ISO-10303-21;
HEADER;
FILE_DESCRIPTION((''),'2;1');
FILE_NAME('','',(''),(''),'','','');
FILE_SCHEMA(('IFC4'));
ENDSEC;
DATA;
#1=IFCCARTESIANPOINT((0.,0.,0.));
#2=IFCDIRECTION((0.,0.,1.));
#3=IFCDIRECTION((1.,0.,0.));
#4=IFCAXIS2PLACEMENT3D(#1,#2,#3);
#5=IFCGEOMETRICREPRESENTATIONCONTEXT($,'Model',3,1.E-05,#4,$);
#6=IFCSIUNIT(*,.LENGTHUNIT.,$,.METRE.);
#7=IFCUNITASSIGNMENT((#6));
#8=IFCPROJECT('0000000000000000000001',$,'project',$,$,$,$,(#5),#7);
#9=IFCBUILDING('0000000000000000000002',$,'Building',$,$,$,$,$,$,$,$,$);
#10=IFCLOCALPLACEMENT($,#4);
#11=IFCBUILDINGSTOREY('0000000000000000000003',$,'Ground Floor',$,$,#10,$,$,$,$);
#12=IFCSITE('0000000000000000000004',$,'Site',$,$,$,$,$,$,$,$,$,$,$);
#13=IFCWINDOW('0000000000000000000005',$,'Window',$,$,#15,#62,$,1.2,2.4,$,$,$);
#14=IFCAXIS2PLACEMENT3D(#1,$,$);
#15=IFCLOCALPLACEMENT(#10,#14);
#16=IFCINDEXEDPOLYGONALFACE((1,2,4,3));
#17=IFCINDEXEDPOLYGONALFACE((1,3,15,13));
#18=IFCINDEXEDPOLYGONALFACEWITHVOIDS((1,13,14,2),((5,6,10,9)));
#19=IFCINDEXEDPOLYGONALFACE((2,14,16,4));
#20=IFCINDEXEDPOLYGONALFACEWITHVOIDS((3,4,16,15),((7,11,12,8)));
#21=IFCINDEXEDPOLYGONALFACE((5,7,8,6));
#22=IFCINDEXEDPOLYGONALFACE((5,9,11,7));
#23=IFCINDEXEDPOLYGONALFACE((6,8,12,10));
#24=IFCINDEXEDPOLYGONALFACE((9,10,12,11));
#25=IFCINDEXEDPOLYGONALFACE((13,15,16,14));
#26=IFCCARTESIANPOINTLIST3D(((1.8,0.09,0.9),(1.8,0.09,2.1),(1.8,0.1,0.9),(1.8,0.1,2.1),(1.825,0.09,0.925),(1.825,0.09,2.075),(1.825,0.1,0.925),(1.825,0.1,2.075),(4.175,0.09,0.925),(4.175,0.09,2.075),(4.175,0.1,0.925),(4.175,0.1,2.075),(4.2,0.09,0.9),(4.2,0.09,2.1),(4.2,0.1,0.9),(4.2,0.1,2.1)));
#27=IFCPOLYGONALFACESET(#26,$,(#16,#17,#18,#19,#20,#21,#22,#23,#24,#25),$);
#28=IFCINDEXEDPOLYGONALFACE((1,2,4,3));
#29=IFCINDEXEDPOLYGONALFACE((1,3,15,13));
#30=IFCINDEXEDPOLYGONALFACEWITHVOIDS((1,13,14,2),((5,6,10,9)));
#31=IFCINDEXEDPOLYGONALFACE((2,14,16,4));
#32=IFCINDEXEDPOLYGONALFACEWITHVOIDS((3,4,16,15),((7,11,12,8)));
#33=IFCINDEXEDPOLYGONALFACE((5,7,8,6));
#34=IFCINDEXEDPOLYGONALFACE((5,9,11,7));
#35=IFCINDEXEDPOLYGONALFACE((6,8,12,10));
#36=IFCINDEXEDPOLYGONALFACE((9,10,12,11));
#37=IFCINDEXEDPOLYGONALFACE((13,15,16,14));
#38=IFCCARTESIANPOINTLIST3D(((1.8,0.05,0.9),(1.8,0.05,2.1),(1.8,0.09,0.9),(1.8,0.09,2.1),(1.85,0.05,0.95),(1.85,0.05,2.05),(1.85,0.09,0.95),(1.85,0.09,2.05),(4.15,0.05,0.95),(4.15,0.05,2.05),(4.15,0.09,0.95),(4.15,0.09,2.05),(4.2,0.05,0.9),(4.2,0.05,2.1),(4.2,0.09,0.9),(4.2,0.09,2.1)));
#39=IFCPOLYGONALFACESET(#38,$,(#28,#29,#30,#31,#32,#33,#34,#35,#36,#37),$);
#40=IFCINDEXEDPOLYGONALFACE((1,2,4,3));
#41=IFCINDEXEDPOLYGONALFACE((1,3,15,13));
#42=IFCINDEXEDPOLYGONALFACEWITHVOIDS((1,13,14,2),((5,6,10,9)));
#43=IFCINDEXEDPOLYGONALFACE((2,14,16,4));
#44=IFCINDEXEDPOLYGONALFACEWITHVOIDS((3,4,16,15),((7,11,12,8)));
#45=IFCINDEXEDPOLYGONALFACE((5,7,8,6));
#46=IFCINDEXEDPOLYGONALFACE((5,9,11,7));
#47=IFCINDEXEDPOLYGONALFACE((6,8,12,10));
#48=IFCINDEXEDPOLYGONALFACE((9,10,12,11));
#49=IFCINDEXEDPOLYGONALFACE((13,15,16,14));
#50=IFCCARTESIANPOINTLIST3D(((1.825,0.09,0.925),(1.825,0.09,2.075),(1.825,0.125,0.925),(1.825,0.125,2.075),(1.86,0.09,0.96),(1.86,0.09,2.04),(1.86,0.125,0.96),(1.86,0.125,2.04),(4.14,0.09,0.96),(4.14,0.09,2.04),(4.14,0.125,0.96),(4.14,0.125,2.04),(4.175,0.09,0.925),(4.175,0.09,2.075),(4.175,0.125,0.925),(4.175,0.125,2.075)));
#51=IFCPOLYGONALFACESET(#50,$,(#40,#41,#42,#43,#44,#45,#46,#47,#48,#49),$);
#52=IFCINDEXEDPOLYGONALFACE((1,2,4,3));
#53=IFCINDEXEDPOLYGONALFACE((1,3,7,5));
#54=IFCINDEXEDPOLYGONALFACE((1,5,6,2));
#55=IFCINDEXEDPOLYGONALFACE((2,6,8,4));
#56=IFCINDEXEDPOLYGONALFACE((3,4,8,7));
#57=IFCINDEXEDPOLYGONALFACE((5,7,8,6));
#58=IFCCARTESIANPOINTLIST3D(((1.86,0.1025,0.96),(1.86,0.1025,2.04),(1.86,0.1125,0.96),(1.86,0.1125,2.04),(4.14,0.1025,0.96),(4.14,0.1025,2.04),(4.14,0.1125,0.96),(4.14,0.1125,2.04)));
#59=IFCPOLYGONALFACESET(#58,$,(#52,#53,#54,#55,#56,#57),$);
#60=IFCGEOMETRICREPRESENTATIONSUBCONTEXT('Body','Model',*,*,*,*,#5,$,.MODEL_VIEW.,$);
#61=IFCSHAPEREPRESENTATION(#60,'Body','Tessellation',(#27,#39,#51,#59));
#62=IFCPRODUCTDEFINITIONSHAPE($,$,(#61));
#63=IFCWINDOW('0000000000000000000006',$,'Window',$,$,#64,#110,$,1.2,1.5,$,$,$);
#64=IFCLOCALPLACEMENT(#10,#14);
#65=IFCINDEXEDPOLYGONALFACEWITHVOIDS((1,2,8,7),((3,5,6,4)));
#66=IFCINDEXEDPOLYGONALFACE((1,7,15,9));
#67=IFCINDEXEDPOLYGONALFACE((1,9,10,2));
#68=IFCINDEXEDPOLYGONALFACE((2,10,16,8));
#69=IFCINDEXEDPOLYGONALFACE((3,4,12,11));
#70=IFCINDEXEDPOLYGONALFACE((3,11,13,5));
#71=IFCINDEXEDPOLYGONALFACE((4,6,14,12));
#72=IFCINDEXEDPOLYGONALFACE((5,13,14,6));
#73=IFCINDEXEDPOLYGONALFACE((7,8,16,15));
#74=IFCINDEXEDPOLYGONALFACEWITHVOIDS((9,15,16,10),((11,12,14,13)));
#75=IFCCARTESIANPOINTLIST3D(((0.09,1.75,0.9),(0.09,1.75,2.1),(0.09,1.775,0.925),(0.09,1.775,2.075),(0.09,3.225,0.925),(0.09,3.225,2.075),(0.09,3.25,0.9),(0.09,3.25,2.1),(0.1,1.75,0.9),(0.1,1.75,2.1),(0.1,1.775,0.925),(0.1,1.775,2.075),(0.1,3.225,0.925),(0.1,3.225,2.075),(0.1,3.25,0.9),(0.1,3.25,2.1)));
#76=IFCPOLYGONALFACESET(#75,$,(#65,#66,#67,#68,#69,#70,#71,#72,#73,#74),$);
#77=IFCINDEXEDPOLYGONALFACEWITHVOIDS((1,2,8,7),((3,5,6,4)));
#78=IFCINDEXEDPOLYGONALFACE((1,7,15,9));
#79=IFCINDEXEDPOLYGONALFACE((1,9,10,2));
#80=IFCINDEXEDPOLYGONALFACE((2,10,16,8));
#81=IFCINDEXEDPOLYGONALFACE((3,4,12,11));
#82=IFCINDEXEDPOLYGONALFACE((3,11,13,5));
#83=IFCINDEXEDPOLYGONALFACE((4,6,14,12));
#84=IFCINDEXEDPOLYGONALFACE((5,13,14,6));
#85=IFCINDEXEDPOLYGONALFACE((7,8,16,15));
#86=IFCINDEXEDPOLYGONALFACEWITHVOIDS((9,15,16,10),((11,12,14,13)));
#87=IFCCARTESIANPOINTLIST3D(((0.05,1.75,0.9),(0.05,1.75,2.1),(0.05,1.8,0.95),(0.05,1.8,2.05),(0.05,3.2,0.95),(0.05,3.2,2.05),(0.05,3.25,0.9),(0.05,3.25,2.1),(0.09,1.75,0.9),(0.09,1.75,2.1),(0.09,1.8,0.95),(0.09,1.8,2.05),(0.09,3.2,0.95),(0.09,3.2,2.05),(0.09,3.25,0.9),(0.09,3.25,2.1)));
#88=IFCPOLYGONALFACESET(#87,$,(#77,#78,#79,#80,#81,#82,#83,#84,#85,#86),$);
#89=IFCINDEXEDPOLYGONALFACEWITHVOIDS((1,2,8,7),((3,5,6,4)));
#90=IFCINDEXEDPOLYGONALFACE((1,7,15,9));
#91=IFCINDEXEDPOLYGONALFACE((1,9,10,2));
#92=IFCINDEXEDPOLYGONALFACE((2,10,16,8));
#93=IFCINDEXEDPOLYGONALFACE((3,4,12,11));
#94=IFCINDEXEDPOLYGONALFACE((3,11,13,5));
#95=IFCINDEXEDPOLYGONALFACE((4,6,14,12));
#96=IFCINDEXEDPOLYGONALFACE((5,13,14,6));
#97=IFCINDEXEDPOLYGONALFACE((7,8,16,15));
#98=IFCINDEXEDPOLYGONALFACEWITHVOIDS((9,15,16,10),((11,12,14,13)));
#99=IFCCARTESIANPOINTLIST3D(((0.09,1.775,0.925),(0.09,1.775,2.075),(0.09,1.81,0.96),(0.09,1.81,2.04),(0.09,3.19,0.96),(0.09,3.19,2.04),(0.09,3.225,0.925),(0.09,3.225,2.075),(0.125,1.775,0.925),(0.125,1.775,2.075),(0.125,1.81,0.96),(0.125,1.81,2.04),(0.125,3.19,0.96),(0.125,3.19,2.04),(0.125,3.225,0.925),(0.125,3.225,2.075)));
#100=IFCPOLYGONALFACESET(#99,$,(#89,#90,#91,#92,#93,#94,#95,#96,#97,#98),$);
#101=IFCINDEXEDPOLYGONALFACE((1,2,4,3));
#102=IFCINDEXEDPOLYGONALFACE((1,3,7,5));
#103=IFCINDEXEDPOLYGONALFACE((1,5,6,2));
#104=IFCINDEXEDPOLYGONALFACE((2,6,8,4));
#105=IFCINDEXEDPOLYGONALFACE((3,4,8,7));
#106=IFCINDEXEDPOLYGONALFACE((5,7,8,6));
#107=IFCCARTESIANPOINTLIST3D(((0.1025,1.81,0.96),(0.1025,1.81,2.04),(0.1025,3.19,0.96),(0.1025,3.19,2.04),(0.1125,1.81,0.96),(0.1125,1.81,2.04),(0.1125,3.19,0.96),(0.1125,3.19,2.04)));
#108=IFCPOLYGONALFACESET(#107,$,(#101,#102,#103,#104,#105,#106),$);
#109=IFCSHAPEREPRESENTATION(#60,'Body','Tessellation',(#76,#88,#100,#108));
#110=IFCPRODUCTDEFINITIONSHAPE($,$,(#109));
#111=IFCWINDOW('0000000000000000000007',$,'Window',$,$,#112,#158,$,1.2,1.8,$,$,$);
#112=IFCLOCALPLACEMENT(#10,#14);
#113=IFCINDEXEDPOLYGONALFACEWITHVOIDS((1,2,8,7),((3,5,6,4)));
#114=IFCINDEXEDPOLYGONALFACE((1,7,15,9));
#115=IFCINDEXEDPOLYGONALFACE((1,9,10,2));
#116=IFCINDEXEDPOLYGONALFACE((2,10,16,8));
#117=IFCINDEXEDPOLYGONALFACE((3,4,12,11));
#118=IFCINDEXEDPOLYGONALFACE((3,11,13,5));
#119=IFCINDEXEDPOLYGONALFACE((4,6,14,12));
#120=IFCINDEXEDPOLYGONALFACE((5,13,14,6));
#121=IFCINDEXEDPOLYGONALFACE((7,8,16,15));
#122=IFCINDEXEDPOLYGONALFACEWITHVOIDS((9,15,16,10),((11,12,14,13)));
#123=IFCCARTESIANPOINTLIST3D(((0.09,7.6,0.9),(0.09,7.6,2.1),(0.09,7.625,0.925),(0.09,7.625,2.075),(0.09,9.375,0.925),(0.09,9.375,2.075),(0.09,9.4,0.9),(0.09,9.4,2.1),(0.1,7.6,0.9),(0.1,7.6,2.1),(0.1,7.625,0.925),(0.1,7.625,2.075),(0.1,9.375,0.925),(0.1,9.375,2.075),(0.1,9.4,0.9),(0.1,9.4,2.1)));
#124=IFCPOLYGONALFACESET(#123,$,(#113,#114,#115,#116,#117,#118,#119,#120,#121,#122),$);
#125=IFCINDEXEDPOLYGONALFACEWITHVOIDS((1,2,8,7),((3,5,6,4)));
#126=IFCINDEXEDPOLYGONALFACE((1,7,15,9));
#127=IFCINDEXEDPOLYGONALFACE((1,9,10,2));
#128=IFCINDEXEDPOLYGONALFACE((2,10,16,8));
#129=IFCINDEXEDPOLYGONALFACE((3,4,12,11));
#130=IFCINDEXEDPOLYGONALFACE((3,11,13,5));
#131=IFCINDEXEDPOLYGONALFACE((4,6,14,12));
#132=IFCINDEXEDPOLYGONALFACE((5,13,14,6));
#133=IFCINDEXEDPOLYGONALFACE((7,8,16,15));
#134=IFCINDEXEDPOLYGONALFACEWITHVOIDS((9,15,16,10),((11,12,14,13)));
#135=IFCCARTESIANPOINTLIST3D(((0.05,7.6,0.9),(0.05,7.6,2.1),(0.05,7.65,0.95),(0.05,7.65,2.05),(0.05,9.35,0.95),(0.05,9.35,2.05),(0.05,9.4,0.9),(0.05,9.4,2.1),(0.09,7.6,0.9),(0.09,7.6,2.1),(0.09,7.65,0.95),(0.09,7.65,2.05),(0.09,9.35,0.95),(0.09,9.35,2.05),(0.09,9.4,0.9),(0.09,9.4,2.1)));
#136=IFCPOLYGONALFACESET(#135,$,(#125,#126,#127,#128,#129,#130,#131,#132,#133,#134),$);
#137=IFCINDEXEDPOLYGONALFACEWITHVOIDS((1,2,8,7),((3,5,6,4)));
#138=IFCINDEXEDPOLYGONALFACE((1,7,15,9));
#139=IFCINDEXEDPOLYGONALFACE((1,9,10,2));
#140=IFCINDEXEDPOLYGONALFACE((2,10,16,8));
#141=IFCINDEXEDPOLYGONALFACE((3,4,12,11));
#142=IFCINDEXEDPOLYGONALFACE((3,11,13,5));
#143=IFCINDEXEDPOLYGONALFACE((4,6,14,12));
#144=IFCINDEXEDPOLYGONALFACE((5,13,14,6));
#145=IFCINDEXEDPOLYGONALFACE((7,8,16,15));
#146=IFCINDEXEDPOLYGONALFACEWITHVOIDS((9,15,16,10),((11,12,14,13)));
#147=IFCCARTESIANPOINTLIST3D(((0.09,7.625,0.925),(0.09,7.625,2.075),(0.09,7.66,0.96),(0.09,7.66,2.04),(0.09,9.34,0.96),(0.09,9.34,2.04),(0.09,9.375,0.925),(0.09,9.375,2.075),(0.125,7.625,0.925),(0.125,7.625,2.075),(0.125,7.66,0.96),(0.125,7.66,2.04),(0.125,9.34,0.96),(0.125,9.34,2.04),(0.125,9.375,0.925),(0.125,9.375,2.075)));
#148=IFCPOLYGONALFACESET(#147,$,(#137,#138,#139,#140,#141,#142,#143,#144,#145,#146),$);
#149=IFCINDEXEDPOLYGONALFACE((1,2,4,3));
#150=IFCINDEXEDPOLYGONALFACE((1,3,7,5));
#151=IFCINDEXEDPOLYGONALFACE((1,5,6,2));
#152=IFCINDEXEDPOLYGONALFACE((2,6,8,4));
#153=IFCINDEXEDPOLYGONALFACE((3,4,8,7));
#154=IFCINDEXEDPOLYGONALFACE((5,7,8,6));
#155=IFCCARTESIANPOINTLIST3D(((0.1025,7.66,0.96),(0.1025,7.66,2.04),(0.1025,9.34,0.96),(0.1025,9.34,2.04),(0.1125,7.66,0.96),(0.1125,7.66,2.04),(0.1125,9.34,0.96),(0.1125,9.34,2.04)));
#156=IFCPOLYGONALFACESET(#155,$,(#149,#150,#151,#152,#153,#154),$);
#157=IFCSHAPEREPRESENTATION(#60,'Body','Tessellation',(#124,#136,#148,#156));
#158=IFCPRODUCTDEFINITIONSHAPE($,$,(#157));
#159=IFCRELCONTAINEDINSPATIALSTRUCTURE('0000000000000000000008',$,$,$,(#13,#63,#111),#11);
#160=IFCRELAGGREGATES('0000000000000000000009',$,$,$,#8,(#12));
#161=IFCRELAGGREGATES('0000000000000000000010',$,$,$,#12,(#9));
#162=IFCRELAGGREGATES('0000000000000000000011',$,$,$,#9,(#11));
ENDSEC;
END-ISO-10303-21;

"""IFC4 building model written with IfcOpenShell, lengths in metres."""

from ifc_helpers import new_model, si_unit, frame, origin_with_axes, place, context, subcontext, project, spatial, line, indexed_curve, outline, extrude, element, save


model = new_model("IFC4")

# Units and contexts
model_context = context("Model", 3, precision=1e-05, world=origin_with_axes())
body_context = subcontext(model_context, "Body", "Model", "MODEL_VIEW")
ifc_project = project(units=[si_unit("LENGTHUNIT", "METRE")], contexts=[model_context])

# Site, building, storey
site = spatial("IfcSite", under=ifc_project, Name="Site")
building = spatial("IfcBuilding", under=site, Name="Building")
storey_placement = place(None, origin_with_axes())
storey = spatial("IfcBuildingStorey", under=building, at=storey_placement, Name="Ground Floor")

# Windows
window_1_placement = place(storey_placement, frame((1.8, 0.0, 0.9), z_axis=(0.0, 0.0, 1.0), x_axis=(1.0, 0.0, 0.0)))
element("IfcWindow", 1, at=window_1_placement, inside=storey, Name="Window", OverallHeight=1.2, OverallWidth=2.4, context=body_context, shape_type="SweptSolid", body=[
    extrude(outline(indexed_curve([(0.0, 0.0), (2.4, 0.0), (2.4, 1.2), (0.0, 1.2)], segments=[line(1, 2, 3, 4, 1)]), holes=[indexed_curve([(0.025, 0.025), (2.375, 0.025), (2.375, 1.175), (0.025, 1.175)], segments=[line(1, 2, 3, 4, 1)])]), frame((0.0, 0.09, 0.0), z_axis=(0.0, -1.0, 0.0), x_axis=(1.0, 0.0, 0.0)), (0.0, 0.0, -1.0), 0.01),
    extrude(outline(indexed_curve([(0.0, 0.0), (2.4, 0.0), (2.4, 1.2), (0.0, 1.2)], segments=[line(1, 2, 3, 4, 1)]), holes=[indexed_curve([(0.05, 0.05), (2.35, 0.05), (2.35, 1.15), (0.05, 1.15)], segments=[line(1, 2, 3, 4, 1)])]), frame((0.0, 0.05, 0.0), z_axis=(0.0, -1.0, 0.0), x_axis=(1.0, 0.0, 0.0)), (0.0, 0.0, -1.0), 0.04),
    extrude(outline(indexed_curve([(0.0, 0.0), (2.35, 0.0), (2.35, 1.15), (0.0, 1.15)], segments=[line(1, 2, 3, 4, 1)]), holes=[indexed_curve([(0.035, 0.035), (2.315, 0.035), (2.315, 1.115), (0.035, 1.115)], segments=[line(1, 2, 3, 4, 1)])]), frame((0.025, 0.09, 0.025), z_axis=(0.0, -1.0, 0.0), x_axis=(1.0, 0.0, 0.0)), (0.0, 0.0, -1.0), 0.035),
    extrude(outline(indexed_curve([(0.035, 0.035), (2.315, 0.035), (2.315, 1.115), (0.035, 1.115)], segments=[line(1, 2, 3, 4, 1)])), frame((0.025, 0.1025, 0.025), z_axis=(0.0, -1.0, 0.0), x_axis=(1.0, 0.0, 0.0)), (0.0, 0.0, -1.0), 0.01),
])
window_2_placement = place(storey_placement, frame((0.0, 3.25, 0.9), z_axis=(0.0, 0.0, 1.0), x_axis=(0.0, -1.0, 0.0)))
element("IfcWindow", 2, at=window_2_placement, inside=storey, Name="Window", OverallHeight=1.2, OverallWidth=1.5, context=body_context, shape_type="SweptSolid", body=[
    extrude(outline(indexed_curve([(0.0, 0.0), (1.5, 0.0), (1.5, 1.2), (0.0, 1.2)], segments=[line(1, 2, 3, 4, 1)]), holes=[indexed_curve([(0.025, 0.025), (1.475, 0.025), (1.475, 1.175), (0.025, 1.175)], segments=[line(1, 2, 3, 4, 1)])]), frame((0.0, 0.09, 0.0), z_axis=(0.0, -1.0, 0.0), x_axis=(1.0, 0.0, 0.0)), (0.0, 0.0, -1.0), 0.01),
    extrude(outline(indexed_curve([(0.0, 0.0), (1.5, 0.0), (1.5, 1.2), (0.0, 1.2)], segments=[line(1, 2, 3, 4, 1)]), holes=[indexed_curve([(0.05, 0.05), (1.45, 0.05), (1.45, 1.15), (0.05, 1.15)], segments=[line(1, 2, 3, 4, 1)])]), frame((0.0, 0.05, 0.0), z_axis=(0.0, -1.0, 0.0), x_axis=(1.0, 0.0, 0.0)), (0.0, 0.0, -1.0), 0.04),
    extrude(outline(indexed_curve([(0.0, 0.0), (1.45, 0.0), (1.45, 1.15), (0.0, 1.15)], segments=[line(1, 2, 3, 4, 1)]), holes=[indexed_curve([(0.035, 0.035), (1.415, 0.035), (1.415, 1.115), (0.035, 1.115)], segments=[line(1, 2, 3, 4, 1)])]), frame((0.025, 0.09, 0.025), z_axis=(0.0, -1.0, 0.0), x_axis=(1.0, 0.0, 0.0)), (0.0, 0.0, -1.0), 0.035),
    extrude(outline(indexed_curve([(0.035, 0.035), (1.415, 0.035), (1.415, 1.115), (0.035, 1.115)], segments=[line(1, 2, 3, 4, 1)])), frame((0.025, 0.1025, 0.025), z_axis=(0.0, -1.0, 0.0), x_axis=(1.0, 0.0, 0.0)), (0.0, 0.0, -1.0), 0.01),
])
window_3_placement = place(storey_placement, frame((0.0, 9.4, 0.9), z_axis=(0.0, 0.0, 1.0), x_axis=(0.0, -1.0, 0.0)))
element("IfcWindow", 3, at=window_3_placement, inside=storey, Name="Window", OverallHeight=1.2, OverallWidth=1.8, context=body_context, shape_type="SweptSolid", body=[
    extrude(outline(indexed_curve([(0.0, 0.0), (1.8, 0.0), (1.8, 1.2), (0.0, 1.2)], segments=[line(1, 2, 3, 4, 1)]), holes=[indexed_curve([(0.025, 0.025), (1.775, 0.025), (1.775, 1.175), (0.025, 1.175)], segments=[line(1, 2, 3, 4, 1)])]), frame((0.0, 0.09, 0.0), z_axis=(0.0, -1.0, 0.0), x_axis=(1.0, 0.0, 0.0)), (0.0, 0.0, -1.0), 0.01),
    extrude(outline(indexed_curve([(0.0, 0.0), (1.8, 0.0), (1.8, 1.2), (0.0, 1.2)], segments=[line(1, 2, 3, 4, 1)]), holes=[indexed_curve([(0.05, 0.05), (1.75, 0.05), (1.75, 1.15), (0.05, 1.15)], segments=[line(1, 2, 3, 4, 1)])]), frame((0.0, 0.05, 0.0), z_axis=(0.0, -1.0, 0.0), x_axis=(1.0, 0.0, 0.0)), (0.0, 0.0, -1.0), 0.04),
    extrude(outline(indexed_curve([(0.0, 0.0), (1.75, 0.0), (1.75, 1.15), (0.0, 1.15)], segments=[line(1, 2, 3, 4, 1)]), holes=[indexed_curve([(0.035, 0.035), (1.715, 0.035), (1.715, 1.115), (0.035, 1.115)], segments=[line(1, 2, 3, 4, 1)])]), frame((0.025, 0.09, 0.025), z_axis=(0.0, -1.0, 0.0), x_axis=(1.0, 0.0, 0.0)), (0.0, 0.0, -1.0), 0.035),
    extrude(outline(indexed_curve([(0.035, 0.035), (1.715, 0.035), (1.715, 1.115), (0.035, 1.115)], segments=[line(1, 2, 3, 4, 1)])), frame((0.025, 0.1025, 0.025), z_axis=(0.0, -1.0, 0.0), x_axis=(1.0, 0.0, 0.0)), (0.0, 0.0, -1.0), 0.01),
])

save(model, "model.ifc")
